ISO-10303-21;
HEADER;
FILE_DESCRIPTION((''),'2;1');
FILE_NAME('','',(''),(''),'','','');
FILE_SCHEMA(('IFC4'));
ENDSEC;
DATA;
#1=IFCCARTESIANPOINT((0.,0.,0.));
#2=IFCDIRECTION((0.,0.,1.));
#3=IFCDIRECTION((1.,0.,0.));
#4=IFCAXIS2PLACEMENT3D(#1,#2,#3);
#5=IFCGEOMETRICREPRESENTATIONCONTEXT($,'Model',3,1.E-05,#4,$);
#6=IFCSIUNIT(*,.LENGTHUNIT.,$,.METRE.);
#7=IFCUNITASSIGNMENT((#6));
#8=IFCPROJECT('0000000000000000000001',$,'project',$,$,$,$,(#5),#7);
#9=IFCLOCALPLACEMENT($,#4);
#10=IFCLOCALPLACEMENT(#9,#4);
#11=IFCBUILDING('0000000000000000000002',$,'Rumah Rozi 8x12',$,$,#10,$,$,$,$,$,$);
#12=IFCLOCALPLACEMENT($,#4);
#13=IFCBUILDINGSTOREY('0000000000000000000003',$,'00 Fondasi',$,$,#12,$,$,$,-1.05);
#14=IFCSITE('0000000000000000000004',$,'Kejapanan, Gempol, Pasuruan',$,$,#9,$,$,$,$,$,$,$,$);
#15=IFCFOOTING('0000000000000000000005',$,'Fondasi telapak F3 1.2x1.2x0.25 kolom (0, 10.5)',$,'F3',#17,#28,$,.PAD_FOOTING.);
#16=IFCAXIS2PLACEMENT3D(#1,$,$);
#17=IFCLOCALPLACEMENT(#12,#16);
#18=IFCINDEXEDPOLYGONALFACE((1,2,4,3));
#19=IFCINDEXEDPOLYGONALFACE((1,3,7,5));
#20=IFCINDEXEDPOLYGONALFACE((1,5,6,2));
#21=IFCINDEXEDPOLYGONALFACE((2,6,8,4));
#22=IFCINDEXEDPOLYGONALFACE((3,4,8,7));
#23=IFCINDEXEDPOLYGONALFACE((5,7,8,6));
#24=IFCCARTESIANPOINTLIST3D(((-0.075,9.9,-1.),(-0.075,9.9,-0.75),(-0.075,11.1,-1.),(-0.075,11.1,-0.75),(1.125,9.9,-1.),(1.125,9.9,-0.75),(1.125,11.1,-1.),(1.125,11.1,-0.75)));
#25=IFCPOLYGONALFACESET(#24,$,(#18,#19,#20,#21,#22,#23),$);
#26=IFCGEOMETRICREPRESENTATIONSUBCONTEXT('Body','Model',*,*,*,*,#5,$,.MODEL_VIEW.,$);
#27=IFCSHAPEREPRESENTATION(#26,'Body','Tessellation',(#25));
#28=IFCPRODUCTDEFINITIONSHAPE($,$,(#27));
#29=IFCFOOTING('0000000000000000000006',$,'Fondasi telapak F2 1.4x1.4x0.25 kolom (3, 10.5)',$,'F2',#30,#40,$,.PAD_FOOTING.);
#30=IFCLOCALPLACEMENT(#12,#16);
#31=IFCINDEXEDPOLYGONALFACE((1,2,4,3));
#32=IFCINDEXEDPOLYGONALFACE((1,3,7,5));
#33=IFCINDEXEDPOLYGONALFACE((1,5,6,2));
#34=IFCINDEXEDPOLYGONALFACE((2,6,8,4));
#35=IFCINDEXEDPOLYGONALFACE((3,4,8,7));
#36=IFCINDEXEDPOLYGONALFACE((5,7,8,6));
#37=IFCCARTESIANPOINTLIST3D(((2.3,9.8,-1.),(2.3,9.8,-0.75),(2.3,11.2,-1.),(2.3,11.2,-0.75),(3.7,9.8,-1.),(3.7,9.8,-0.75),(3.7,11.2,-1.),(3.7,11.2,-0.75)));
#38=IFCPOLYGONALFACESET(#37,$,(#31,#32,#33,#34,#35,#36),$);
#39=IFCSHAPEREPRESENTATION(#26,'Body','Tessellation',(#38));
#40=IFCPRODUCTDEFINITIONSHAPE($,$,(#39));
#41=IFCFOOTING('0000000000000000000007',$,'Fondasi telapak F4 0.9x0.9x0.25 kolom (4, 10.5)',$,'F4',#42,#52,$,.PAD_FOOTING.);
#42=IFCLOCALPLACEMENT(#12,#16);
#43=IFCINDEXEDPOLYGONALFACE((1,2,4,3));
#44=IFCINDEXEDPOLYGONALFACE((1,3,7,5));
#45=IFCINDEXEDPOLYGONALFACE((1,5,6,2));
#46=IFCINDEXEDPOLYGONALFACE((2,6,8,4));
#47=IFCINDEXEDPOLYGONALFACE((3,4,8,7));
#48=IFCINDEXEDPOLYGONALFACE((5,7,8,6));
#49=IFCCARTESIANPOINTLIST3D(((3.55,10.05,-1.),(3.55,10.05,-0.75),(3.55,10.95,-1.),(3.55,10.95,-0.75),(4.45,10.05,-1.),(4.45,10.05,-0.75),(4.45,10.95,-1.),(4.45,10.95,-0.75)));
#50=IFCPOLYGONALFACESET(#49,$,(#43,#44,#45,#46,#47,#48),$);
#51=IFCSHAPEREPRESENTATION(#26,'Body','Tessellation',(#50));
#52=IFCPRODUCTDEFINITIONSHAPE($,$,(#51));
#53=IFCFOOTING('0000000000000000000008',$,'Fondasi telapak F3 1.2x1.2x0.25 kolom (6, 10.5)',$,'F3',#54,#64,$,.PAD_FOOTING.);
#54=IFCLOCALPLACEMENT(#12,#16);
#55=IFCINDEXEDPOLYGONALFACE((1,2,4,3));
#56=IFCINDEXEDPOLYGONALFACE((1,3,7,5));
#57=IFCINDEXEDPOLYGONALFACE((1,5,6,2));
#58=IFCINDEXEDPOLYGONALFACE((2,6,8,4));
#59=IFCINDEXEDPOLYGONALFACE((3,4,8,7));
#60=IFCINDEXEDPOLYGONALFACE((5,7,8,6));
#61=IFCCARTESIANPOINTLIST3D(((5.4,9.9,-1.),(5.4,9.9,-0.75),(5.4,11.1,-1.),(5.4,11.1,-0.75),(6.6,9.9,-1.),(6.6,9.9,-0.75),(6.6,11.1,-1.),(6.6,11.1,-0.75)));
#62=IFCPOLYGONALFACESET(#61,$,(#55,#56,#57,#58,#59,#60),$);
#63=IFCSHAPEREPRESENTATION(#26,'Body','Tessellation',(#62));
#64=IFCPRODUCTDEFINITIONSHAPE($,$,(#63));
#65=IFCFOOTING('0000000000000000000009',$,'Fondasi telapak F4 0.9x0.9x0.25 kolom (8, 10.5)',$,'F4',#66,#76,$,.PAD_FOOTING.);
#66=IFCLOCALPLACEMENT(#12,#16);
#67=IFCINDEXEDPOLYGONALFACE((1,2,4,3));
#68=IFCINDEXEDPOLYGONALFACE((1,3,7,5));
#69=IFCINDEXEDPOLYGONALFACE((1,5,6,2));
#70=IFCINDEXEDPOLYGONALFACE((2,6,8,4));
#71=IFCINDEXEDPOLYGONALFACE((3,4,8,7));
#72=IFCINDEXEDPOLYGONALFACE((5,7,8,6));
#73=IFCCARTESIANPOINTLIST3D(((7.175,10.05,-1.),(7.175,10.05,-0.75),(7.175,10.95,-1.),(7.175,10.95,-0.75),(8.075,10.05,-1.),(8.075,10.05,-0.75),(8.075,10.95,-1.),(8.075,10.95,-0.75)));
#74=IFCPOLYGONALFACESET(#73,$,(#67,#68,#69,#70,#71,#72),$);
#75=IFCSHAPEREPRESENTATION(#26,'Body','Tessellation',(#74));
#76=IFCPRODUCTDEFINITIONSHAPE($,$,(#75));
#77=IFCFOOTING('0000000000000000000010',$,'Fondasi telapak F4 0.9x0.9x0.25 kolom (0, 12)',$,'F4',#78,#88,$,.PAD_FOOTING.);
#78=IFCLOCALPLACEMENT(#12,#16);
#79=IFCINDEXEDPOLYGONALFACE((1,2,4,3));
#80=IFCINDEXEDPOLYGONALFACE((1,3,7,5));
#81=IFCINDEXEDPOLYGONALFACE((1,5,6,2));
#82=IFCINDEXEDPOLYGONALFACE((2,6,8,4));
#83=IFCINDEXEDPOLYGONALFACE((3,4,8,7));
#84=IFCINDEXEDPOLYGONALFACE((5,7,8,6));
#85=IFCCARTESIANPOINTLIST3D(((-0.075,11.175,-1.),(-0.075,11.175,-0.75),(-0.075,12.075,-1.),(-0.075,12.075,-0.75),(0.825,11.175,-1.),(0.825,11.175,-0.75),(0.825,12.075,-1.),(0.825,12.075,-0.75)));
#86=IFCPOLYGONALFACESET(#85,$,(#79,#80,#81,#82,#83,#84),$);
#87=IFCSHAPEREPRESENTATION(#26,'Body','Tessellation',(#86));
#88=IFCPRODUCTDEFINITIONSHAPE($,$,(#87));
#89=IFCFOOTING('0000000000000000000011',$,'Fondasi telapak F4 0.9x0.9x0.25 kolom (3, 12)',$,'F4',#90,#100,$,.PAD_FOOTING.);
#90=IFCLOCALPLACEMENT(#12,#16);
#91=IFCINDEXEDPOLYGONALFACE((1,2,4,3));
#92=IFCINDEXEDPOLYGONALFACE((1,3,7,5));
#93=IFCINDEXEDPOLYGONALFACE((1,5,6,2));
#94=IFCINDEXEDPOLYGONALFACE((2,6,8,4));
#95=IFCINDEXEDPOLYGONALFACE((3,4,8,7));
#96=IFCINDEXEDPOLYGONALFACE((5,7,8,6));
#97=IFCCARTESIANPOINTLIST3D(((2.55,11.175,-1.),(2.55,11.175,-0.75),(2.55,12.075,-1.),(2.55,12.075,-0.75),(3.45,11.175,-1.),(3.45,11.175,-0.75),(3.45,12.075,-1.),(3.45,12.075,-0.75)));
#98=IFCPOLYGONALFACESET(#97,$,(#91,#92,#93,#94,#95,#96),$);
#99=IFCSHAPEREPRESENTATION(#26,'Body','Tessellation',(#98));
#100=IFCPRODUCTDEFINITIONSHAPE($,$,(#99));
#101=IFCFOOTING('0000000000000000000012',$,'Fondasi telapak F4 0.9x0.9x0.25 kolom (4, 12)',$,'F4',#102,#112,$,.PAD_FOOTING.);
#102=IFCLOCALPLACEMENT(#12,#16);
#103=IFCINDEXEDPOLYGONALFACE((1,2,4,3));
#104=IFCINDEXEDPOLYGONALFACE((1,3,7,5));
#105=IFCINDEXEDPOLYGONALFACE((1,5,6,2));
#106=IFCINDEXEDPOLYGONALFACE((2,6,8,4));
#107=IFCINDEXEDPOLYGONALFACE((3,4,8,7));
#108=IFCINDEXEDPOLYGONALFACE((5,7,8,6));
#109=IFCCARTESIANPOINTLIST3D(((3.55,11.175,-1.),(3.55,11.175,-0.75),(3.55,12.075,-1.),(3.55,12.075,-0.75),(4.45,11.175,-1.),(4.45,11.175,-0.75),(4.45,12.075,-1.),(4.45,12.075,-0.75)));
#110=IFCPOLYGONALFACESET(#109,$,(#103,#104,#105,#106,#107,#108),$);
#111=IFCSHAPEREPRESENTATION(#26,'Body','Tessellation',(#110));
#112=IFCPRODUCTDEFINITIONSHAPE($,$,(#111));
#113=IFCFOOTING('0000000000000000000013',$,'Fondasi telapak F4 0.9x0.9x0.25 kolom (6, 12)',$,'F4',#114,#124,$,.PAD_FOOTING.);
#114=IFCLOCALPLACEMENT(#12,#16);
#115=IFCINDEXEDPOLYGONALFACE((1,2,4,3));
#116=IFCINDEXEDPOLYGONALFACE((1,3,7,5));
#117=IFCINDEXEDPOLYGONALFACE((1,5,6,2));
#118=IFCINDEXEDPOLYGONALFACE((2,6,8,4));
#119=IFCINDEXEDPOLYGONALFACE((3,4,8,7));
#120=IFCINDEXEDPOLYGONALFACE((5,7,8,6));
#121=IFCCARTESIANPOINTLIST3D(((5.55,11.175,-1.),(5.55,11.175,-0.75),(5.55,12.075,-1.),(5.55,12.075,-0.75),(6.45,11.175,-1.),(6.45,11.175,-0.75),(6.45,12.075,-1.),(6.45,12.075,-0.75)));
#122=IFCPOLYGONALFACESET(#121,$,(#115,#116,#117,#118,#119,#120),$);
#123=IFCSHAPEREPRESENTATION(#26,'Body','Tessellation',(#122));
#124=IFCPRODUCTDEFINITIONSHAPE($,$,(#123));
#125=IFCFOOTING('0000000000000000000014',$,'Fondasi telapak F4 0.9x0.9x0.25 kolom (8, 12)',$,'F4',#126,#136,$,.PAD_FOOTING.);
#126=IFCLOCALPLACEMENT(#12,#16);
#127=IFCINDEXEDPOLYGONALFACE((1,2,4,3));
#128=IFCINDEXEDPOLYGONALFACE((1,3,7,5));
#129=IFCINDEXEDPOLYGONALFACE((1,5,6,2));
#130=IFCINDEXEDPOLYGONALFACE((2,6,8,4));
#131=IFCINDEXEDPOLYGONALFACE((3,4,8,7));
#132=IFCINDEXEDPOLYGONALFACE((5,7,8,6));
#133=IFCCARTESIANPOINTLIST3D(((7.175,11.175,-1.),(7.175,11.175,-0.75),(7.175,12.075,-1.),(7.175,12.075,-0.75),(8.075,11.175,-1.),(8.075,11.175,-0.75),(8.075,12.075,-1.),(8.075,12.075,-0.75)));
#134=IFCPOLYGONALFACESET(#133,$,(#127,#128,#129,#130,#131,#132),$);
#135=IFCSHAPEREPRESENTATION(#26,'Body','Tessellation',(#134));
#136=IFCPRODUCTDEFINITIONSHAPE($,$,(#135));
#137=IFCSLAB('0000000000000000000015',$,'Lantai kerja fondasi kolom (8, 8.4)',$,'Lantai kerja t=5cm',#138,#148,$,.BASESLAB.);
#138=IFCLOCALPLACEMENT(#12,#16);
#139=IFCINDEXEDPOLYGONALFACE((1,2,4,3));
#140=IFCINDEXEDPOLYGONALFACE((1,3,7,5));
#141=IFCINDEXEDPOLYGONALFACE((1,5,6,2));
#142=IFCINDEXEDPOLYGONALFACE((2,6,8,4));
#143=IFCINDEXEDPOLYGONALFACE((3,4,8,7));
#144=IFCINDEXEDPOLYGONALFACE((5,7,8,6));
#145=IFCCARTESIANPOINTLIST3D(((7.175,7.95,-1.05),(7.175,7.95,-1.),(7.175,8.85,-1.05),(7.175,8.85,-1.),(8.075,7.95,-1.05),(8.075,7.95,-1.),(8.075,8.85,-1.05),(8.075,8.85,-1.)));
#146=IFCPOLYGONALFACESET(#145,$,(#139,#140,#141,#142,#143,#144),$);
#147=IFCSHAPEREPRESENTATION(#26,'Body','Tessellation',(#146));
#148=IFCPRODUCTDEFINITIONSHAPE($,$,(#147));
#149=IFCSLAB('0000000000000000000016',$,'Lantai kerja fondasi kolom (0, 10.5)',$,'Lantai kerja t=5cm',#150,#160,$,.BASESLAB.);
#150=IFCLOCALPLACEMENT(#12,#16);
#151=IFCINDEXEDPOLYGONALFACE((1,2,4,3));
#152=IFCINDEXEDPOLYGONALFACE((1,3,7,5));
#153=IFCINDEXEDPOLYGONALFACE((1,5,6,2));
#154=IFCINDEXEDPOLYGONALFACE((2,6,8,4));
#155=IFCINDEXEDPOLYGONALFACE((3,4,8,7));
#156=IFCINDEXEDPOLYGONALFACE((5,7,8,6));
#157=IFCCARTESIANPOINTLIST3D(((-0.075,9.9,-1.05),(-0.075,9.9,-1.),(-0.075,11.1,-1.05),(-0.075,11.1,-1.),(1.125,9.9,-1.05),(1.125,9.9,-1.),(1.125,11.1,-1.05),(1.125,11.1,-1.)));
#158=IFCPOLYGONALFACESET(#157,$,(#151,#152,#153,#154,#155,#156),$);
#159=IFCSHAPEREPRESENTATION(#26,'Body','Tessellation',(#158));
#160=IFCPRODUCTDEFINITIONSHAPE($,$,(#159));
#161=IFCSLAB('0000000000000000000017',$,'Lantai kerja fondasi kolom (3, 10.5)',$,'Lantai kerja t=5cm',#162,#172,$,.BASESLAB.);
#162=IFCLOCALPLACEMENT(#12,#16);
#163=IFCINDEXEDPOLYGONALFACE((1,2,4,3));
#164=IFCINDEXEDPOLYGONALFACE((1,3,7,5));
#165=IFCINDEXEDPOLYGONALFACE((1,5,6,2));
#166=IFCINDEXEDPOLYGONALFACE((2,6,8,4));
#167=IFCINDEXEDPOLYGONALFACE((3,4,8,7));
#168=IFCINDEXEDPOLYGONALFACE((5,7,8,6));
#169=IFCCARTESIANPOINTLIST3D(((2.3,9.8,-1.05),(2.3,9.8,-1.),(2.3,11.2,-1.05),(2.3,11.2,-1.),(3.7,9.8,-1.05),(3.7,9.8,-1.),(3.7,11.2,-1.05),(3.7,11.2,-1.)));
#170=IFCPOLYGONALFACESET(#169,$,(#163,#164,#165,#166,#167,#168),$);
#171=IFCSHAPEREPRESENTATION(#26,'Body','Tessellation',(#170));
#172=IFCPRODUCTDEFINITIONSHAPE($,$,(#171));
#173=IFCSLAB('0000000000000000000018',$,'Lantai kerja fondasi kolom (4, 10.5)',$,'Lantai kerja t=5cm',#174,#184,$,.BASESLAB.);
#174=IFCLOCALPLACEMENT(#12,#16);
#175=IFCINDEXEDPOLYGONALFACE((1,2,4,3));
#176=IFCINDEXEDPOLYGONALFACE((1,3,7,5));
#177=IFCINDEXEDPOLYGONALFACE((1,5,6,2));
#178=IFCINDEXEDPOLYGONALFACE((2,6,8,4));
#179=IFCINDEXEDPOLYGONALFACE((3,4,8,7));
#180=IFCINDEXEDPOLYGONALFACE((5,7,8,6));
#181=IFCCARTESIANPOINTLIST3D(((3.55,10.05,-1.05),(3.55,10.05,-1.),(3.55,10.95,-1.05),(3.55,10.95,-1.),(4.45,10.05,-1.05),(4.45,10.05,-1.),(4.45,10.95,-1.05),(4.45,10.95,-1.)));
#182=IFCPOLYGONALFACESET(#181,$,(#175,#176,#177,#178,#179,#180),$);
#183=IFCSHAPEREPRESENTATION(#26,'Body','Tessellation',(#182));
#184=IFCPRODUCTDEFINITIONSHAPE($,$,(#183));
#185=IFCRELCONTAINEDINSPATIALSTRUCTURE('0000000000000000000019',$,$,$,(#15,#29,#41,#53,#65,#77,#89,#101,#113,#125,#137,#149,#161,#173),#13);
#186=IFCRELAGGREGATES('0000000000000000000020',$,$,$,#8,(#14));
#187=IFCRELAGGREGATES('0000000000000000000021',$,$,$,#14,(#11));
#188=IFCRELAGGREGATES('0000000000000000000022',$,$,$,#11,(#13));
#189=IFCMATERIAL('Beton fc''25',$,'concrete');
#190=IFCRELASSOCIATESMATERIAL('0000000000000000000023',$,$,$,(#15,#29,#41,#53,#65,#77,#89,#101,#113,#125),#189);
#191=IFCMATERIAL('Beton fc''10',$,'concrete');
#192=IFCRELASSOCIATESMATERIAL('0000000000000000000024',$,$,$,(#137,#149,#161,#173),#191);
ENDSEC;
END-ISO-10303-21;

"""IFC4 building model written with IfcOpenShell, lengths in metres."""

from ifc_helpers import new_model, si_unit, frame, origin_with_axes, place, context, subcontext, project, spatial, line, indexed_curve, outline, extrude, material, element, save


model = new_model("IFC4")

# Units and contexts
model_context = context("Model", 3, precision=1e-05, world=origin_with_axes())
body_context = subcontext(model_context, "Body", "Model", "MODEL_VIEW")
ifc_project = project(units=[si_unit("LENGTHUNIT", "METRE")], contexts=[model_context])

# Site, building, storey
site_placement = place(None, origin_with_axes())
site = spatial("IfcSite", under=ifc_project, at=site_placement, Name="Kejapanan, Gempol, Pasuruan")
building_placement = place(site_placement, origin_with_axes())
building = spatial("IfcBuilding", under=site, at=building_placement, Name="Rumah Rozi 8x12")
storey_placement = place(None, origin_with_axes())
storey = spatial("IfcBuildingStorey", under=building, at=storey_placement, Name="00 Fondasi", Elevation=-1.05)

# Footings
ifc_material_1 = material(Name="Beton fc'25", Category="concrete")
footing_1_placement = place(storey_placement, origin_with_axes())
element("IfcFooting", 1, at=footing_1_placement, inside=storey, material=ifc_material_1, Name="Fondasi telapak F3 1.2x1.2x0.25 kolom (0, 10.5)", ObjectType="F3", PredefinedType="PAD_FOOTING", context=body_context, shape_type="SweptSolid", body=[
    extrude(outline(indexed_curve([(-0.075, 9.9), (1.125, 9.9), (1.125, 11.1), (-0.075, 11.1)], segments=[line(1, 2, 3, 4, 1)])), frame((0.0, 0.0, -1.0), z_axis=(0.0, 0.0, 1.0), x_axis=(1.0, 0.0, 0.0)), (0.0, 0.0, 1.0), 0.25),
])
footing_2_placement = place(storey_placement, origin_with_axes())
element("IfcFooting", 2, at=footing_2_placement, inside=storey, material=ifc_material_1, Name="Fondasi telapak F2 1.4x1.4x0.25 kolom (3, 10.5)", ObjectType="F2", PredefinedType="PAD_FOOTING", context=body_context, shape_type="SweptSolid", body=[
    extrude(outline(indexed_curve([(2.3, 9.8), (3.7, 9.8), (3.7, 11.2), (2.3, 11.2)], segments=[line(1, 2, 3, 4, 1)])), frame((0.0, 0.0, -1.0), z_axis=(0.0, 0.0, 1.0), x_axis=(1.0, 0.0, 0.0)), (0.0, 0.0, 1.0), 0.25),
])
footing_3_placement = place(storey_placement, origin_with_axes())
element("IfcFooting", 3, at=footing_3_placement, inside=storey, material=ifc_material_1, Name="Fondasi telapak F4 0.9x0.9x0.25 kolom (4, 10.5)", ObjectType="F4", PredefinedType="PAD_FOOTING", context=body_context, shape_type="SweptSolid", body=[
    extrude(outline(indexed_curve([(3.55, 10.05), (4.45, 10.05), (4.45, 10.95), (3.55, 10.95)], segments=[line(1, 2, 3, 4, 1)])), frame((0.0, 0.0, -1.0), z_axis=(0.0, 0.0, 1.0), x_axis=(1.0, 0.0, 0.0)), (0.0, 0.0, 1.0), 0.25),
])
footing_4_placement = place(storey_placement, origin_with_axes())
element("IfcFooting", 4, at=footing_4_placement, inside=storey, material=ifc_material_1, Name="Fondasi telapak F3 1.2x1.2x0.25 kolom (6, 10.5)", ObjectType="F3", PredefinedType="PAD_FOOTING", context=body_context, shape_type="SweptSolid", body=[
    extrude(outline(indexed_curve([(5.4, 9.9), (6.6, 9.9), (6.6, 11.1), (5.4, 11.1)], segments=[line(1, 2, 3, 4, 1)])), frame((0.0, 0.0, -1.0), z_axis=(0.0, 0.0, 1.0), x_axis=(1.0, 0.0, 0.0)), (0.0, 0.0, 1.0), 0.25),
])
footing_5_placement = place(storey_placement, origin_with_axes())
element("IfcFooting", 5, at=footing_5_placement, inside=storey, material=ifc_material_1, Name="Fondasi telapak F4 0.9x0.9x0.25 kolom (8, 10.5)", ObjectType="F4", PredefinedType="PAD_FOOTING", context=body_context, shape_type="SweptSolid", body=[
    extrude(outline(indexed_curve([(7.175, 10.05), (8.075, 10.05), (8.075, 10.95), (7.175, 10.95)], segments=[line(1, 2, 3, 4, 1)])), frame((0.0, 0.0, -1.0), z_axis=(0.0, 0.0, 1.0), x_axis=(1.0, 0.0, 0.0)), (0.0, 0.0, 1.0), 0.25),
])
footing_6_placement = place(storey_placement, origin_with_axes())
element("IfcFooting", 6, at=footing_6_placement, inside=storey, material=ifc_material_1, Name="Fondasi telapak F4 0.9x0.9x0.25 kolom (0, 12)", ObjectType="F4", PredefinedType="PAD_FOOTING", context=body_context, shape_type="SweptSolid", body=[
    extrude(outline(indexed_curve([(-0.075, 11.175), (0.825, 11.175), (0.825, 12.075), (-0.075, 12.075)], segments=[line(1, 2, 3, 4, 1)])), frame((0.0, 0.0, -1.0), z_axis=(0.0, 0.0, 1.0), x_axis=(1.0, 0.0, 0.0)), (0.0, 0.0, 1.0), 0.25),
])
footing_7_placement = place(storey_placement, origin_with_axes())
element("IfcFooting", 7, at=footing_7_placement, inside=storey, material=ifc_material_1, Name="Fondasi telapak F4 0.9x0.9x0.25 kolom (3, 12)", ObjectType="F4", PredefinedType="PAD_FOOTING", context=body_context, shape_type="SweptSolid", body=[
    extrude(outline(indexed_curve([(2.55, 11.175), (3.45, 11.175), (3.45, 12.075), (2.55, 12.075)], segments=[line(1, 2, 3, 4, 1)])), frame((0.0, 0.0, -1.0), z_axis=(0.0, 0.0, 1.0), x_axis=(1.0, 0.0, 0.0)), (0.0, 0.0, 1.0), 0.25),
])
footing_8_placement = place(storey_placement, origin_with_axes())
element("IfcFooting", 8, at=footing_8_placement, inside=storey, material=ifc_material_1, Name="Fondasi telapak F4 0.9x0.9x0.25 kolom (4, 12)", ObjectType="F4", PredefinedType="PAD_FOOTING", context=body_context, shape_type="SweptSolid", body=[
    extrude(outline(indexed_curve([(3.55, 11.175), (4.45, 11.175), (4.45, 12.075), (3.55, 12.075)], segments=[line(1, 2, 3, 4, 1)])), frame((0.0, 0.0, -1.0), z_axis=(0.0, 0.0, 1.0), x_axis=(1.0, 0.0, 0.0)), (0.0, 0.0, 1.0), 0.25),
])
footing_9_placement = place(storey_placement, origin_with_axes())
element("IfcFooting", 9, at=footing_9_placement, inside=storey, material=ifc_material_1, Name="Fondasi telapak F4 0.9x0.9x0.25 kolom (6, 12)", ObjectType="F4", PredefinedType="PAD_FOOTING", context=body_context, shape_type="SweptSolid", body=[
    extrude(outline(indexed_curve([(5.55, 11.175), (6.45, 11.175), (6.45, 12.075), (5.55, 12.075)], segments=[line(1, 2, 3, 4, 1)])), frame((0.0, 0.0, -1.0), z_axis=(0.0, 0.0, 1.0), x_axis=(1.0, 0.0, 0.0)), (0.0, 0.0, 1.0), 0.25),
])
footing_10_placement = place(storey_placement, origin_with_axes())
element("IfcFooting", 10, at=footing_10_placement, inside=storey, material=ifc_material_1, Name="Fondasi telapak F4 0.9x0.9x0.25 kolom (8, 12)", ObjectType="F4", PredefinedType="PAD_FOOTING", context=body_context, shape_type="SweptSolid", body=[
    extrude(outline(indexed_curve([(7.175, 11.175), (8.075, 11.175), (8.075, 12.075), (7.175, 12.075)], segments=[line(1, 2, 3, 4, 1)])), frame((0.0, 0.0, -1.0), z_axis=(0.0, 0.0, 1.0), x_axis=(1.0, 0.0, 0.0)), (0.0, 0.0, 1.0), 0.25),
])

# Slabs
ifc_material_2 = material(Name="Beton fc'10", Category="concrete")
slab_1_placement = place(storey_placement, origin_with_axes())
element("IfcSlab", 11, at=slab_1_placement, inside=storey, material=ifc_material_2, Name="Lantai kerja fondasi kolom (8, 8.4)", ObjectType="Lantai kerja t=5cm", PredefinedType="BASESLAB", context=body_context, shape_type="SweptSolid", body=[
    extrude(outline(indexed_curve([(7.175, 7.95), (8.075, 7.95), (8.075, 8.85), (7.175, 8.85)], segments=[line(1, 2, 3, 4, 1)])), frame((0.0, 0.0, -1.05), z_axis=(0.0, 0.0, 1.0), x_axis=(1.0, 0.0, 0.0)), (0.0, 0.0, 1.0), 0.05),
])
slab_2_placement = place(storey_placement, origin_with_axes())
element("IfcSlab", 12, at=slab_2_placement, inside=storey, material=ifc_material_2, Name="Lantai kerja fondasi kolom (0, 10.5)", ObjectType="Lantai kerja t=5cm", PredefinedType="BASESLAB", context=body_context, shape_type="SweptSolid", body=[
    extrude(outline(indexed_curve([(-0.075, 9.9), (1.125, 9.9), (1.125, 11.1), (-0.075, 11.1)], segments=[line(1, 2, 3, 4, 1)])), frame((0.0, 0.0, -1.05), z_axis=(0.0, 0.0, 1.0), x_axis=(1.0, 0.0, 0.0)), (0.0, 0.0, 1.0), 0.05),
])
slab_3_placement = place(storey_placement, origin_with_axes())
element("IfcSlab", 13, at=slab_3_placement, inside=storey, material=ifc_material_2, Name="Lantai kerja fondasi kolom (3, 10.5)", ObjectType="Lantai kerja t=5cm", PredefinedType="BASESLAB", context=body_context, shape_type="SweptSolid", body=[
    extrude(outline(indexed_curve([(2.3, 9.8), (3.7, 9.8), (3.7, 11.2), (2.3, 11.2)], segments=[line(1, 2, 3, 4, 1)])), frame((0.0, 0.0, -1.05), z_axis=(0.0, 0.0, 1.0), x_axis=(1.0, 0.0, 0.0)), (0.0, 0.0, 1.0), 0.05),
])
slab_4_placement = place(storey_placement, origin_with_axes())
element("IfcSlab", 14, at=slab_4_placement, inside=storey, material=ifc_material_2, Name="Lantai kerja fondasi kolom (4, 10.5)", ObjectType="Lantai kerja t=5cm", PredefinedType="BASESLAB", context=body_context, shape_type="SweptSolid", body=[
    extrude(outline(indexed_curve([(3.55, 10.05), (4.45, 10.05), (4.45, 10.95), (3.55, 10.95)], segments=[line(1, 2, 3, 4, 1)])), frame((0.0, 0.0, -1.05), z_axis=(0.0, 0.0, 1.0), x_axis=(1.0, 0.0, 0.0)), (0.0, 0.0, 1.0), 0.05),
])

save(model, "model.ifc")
